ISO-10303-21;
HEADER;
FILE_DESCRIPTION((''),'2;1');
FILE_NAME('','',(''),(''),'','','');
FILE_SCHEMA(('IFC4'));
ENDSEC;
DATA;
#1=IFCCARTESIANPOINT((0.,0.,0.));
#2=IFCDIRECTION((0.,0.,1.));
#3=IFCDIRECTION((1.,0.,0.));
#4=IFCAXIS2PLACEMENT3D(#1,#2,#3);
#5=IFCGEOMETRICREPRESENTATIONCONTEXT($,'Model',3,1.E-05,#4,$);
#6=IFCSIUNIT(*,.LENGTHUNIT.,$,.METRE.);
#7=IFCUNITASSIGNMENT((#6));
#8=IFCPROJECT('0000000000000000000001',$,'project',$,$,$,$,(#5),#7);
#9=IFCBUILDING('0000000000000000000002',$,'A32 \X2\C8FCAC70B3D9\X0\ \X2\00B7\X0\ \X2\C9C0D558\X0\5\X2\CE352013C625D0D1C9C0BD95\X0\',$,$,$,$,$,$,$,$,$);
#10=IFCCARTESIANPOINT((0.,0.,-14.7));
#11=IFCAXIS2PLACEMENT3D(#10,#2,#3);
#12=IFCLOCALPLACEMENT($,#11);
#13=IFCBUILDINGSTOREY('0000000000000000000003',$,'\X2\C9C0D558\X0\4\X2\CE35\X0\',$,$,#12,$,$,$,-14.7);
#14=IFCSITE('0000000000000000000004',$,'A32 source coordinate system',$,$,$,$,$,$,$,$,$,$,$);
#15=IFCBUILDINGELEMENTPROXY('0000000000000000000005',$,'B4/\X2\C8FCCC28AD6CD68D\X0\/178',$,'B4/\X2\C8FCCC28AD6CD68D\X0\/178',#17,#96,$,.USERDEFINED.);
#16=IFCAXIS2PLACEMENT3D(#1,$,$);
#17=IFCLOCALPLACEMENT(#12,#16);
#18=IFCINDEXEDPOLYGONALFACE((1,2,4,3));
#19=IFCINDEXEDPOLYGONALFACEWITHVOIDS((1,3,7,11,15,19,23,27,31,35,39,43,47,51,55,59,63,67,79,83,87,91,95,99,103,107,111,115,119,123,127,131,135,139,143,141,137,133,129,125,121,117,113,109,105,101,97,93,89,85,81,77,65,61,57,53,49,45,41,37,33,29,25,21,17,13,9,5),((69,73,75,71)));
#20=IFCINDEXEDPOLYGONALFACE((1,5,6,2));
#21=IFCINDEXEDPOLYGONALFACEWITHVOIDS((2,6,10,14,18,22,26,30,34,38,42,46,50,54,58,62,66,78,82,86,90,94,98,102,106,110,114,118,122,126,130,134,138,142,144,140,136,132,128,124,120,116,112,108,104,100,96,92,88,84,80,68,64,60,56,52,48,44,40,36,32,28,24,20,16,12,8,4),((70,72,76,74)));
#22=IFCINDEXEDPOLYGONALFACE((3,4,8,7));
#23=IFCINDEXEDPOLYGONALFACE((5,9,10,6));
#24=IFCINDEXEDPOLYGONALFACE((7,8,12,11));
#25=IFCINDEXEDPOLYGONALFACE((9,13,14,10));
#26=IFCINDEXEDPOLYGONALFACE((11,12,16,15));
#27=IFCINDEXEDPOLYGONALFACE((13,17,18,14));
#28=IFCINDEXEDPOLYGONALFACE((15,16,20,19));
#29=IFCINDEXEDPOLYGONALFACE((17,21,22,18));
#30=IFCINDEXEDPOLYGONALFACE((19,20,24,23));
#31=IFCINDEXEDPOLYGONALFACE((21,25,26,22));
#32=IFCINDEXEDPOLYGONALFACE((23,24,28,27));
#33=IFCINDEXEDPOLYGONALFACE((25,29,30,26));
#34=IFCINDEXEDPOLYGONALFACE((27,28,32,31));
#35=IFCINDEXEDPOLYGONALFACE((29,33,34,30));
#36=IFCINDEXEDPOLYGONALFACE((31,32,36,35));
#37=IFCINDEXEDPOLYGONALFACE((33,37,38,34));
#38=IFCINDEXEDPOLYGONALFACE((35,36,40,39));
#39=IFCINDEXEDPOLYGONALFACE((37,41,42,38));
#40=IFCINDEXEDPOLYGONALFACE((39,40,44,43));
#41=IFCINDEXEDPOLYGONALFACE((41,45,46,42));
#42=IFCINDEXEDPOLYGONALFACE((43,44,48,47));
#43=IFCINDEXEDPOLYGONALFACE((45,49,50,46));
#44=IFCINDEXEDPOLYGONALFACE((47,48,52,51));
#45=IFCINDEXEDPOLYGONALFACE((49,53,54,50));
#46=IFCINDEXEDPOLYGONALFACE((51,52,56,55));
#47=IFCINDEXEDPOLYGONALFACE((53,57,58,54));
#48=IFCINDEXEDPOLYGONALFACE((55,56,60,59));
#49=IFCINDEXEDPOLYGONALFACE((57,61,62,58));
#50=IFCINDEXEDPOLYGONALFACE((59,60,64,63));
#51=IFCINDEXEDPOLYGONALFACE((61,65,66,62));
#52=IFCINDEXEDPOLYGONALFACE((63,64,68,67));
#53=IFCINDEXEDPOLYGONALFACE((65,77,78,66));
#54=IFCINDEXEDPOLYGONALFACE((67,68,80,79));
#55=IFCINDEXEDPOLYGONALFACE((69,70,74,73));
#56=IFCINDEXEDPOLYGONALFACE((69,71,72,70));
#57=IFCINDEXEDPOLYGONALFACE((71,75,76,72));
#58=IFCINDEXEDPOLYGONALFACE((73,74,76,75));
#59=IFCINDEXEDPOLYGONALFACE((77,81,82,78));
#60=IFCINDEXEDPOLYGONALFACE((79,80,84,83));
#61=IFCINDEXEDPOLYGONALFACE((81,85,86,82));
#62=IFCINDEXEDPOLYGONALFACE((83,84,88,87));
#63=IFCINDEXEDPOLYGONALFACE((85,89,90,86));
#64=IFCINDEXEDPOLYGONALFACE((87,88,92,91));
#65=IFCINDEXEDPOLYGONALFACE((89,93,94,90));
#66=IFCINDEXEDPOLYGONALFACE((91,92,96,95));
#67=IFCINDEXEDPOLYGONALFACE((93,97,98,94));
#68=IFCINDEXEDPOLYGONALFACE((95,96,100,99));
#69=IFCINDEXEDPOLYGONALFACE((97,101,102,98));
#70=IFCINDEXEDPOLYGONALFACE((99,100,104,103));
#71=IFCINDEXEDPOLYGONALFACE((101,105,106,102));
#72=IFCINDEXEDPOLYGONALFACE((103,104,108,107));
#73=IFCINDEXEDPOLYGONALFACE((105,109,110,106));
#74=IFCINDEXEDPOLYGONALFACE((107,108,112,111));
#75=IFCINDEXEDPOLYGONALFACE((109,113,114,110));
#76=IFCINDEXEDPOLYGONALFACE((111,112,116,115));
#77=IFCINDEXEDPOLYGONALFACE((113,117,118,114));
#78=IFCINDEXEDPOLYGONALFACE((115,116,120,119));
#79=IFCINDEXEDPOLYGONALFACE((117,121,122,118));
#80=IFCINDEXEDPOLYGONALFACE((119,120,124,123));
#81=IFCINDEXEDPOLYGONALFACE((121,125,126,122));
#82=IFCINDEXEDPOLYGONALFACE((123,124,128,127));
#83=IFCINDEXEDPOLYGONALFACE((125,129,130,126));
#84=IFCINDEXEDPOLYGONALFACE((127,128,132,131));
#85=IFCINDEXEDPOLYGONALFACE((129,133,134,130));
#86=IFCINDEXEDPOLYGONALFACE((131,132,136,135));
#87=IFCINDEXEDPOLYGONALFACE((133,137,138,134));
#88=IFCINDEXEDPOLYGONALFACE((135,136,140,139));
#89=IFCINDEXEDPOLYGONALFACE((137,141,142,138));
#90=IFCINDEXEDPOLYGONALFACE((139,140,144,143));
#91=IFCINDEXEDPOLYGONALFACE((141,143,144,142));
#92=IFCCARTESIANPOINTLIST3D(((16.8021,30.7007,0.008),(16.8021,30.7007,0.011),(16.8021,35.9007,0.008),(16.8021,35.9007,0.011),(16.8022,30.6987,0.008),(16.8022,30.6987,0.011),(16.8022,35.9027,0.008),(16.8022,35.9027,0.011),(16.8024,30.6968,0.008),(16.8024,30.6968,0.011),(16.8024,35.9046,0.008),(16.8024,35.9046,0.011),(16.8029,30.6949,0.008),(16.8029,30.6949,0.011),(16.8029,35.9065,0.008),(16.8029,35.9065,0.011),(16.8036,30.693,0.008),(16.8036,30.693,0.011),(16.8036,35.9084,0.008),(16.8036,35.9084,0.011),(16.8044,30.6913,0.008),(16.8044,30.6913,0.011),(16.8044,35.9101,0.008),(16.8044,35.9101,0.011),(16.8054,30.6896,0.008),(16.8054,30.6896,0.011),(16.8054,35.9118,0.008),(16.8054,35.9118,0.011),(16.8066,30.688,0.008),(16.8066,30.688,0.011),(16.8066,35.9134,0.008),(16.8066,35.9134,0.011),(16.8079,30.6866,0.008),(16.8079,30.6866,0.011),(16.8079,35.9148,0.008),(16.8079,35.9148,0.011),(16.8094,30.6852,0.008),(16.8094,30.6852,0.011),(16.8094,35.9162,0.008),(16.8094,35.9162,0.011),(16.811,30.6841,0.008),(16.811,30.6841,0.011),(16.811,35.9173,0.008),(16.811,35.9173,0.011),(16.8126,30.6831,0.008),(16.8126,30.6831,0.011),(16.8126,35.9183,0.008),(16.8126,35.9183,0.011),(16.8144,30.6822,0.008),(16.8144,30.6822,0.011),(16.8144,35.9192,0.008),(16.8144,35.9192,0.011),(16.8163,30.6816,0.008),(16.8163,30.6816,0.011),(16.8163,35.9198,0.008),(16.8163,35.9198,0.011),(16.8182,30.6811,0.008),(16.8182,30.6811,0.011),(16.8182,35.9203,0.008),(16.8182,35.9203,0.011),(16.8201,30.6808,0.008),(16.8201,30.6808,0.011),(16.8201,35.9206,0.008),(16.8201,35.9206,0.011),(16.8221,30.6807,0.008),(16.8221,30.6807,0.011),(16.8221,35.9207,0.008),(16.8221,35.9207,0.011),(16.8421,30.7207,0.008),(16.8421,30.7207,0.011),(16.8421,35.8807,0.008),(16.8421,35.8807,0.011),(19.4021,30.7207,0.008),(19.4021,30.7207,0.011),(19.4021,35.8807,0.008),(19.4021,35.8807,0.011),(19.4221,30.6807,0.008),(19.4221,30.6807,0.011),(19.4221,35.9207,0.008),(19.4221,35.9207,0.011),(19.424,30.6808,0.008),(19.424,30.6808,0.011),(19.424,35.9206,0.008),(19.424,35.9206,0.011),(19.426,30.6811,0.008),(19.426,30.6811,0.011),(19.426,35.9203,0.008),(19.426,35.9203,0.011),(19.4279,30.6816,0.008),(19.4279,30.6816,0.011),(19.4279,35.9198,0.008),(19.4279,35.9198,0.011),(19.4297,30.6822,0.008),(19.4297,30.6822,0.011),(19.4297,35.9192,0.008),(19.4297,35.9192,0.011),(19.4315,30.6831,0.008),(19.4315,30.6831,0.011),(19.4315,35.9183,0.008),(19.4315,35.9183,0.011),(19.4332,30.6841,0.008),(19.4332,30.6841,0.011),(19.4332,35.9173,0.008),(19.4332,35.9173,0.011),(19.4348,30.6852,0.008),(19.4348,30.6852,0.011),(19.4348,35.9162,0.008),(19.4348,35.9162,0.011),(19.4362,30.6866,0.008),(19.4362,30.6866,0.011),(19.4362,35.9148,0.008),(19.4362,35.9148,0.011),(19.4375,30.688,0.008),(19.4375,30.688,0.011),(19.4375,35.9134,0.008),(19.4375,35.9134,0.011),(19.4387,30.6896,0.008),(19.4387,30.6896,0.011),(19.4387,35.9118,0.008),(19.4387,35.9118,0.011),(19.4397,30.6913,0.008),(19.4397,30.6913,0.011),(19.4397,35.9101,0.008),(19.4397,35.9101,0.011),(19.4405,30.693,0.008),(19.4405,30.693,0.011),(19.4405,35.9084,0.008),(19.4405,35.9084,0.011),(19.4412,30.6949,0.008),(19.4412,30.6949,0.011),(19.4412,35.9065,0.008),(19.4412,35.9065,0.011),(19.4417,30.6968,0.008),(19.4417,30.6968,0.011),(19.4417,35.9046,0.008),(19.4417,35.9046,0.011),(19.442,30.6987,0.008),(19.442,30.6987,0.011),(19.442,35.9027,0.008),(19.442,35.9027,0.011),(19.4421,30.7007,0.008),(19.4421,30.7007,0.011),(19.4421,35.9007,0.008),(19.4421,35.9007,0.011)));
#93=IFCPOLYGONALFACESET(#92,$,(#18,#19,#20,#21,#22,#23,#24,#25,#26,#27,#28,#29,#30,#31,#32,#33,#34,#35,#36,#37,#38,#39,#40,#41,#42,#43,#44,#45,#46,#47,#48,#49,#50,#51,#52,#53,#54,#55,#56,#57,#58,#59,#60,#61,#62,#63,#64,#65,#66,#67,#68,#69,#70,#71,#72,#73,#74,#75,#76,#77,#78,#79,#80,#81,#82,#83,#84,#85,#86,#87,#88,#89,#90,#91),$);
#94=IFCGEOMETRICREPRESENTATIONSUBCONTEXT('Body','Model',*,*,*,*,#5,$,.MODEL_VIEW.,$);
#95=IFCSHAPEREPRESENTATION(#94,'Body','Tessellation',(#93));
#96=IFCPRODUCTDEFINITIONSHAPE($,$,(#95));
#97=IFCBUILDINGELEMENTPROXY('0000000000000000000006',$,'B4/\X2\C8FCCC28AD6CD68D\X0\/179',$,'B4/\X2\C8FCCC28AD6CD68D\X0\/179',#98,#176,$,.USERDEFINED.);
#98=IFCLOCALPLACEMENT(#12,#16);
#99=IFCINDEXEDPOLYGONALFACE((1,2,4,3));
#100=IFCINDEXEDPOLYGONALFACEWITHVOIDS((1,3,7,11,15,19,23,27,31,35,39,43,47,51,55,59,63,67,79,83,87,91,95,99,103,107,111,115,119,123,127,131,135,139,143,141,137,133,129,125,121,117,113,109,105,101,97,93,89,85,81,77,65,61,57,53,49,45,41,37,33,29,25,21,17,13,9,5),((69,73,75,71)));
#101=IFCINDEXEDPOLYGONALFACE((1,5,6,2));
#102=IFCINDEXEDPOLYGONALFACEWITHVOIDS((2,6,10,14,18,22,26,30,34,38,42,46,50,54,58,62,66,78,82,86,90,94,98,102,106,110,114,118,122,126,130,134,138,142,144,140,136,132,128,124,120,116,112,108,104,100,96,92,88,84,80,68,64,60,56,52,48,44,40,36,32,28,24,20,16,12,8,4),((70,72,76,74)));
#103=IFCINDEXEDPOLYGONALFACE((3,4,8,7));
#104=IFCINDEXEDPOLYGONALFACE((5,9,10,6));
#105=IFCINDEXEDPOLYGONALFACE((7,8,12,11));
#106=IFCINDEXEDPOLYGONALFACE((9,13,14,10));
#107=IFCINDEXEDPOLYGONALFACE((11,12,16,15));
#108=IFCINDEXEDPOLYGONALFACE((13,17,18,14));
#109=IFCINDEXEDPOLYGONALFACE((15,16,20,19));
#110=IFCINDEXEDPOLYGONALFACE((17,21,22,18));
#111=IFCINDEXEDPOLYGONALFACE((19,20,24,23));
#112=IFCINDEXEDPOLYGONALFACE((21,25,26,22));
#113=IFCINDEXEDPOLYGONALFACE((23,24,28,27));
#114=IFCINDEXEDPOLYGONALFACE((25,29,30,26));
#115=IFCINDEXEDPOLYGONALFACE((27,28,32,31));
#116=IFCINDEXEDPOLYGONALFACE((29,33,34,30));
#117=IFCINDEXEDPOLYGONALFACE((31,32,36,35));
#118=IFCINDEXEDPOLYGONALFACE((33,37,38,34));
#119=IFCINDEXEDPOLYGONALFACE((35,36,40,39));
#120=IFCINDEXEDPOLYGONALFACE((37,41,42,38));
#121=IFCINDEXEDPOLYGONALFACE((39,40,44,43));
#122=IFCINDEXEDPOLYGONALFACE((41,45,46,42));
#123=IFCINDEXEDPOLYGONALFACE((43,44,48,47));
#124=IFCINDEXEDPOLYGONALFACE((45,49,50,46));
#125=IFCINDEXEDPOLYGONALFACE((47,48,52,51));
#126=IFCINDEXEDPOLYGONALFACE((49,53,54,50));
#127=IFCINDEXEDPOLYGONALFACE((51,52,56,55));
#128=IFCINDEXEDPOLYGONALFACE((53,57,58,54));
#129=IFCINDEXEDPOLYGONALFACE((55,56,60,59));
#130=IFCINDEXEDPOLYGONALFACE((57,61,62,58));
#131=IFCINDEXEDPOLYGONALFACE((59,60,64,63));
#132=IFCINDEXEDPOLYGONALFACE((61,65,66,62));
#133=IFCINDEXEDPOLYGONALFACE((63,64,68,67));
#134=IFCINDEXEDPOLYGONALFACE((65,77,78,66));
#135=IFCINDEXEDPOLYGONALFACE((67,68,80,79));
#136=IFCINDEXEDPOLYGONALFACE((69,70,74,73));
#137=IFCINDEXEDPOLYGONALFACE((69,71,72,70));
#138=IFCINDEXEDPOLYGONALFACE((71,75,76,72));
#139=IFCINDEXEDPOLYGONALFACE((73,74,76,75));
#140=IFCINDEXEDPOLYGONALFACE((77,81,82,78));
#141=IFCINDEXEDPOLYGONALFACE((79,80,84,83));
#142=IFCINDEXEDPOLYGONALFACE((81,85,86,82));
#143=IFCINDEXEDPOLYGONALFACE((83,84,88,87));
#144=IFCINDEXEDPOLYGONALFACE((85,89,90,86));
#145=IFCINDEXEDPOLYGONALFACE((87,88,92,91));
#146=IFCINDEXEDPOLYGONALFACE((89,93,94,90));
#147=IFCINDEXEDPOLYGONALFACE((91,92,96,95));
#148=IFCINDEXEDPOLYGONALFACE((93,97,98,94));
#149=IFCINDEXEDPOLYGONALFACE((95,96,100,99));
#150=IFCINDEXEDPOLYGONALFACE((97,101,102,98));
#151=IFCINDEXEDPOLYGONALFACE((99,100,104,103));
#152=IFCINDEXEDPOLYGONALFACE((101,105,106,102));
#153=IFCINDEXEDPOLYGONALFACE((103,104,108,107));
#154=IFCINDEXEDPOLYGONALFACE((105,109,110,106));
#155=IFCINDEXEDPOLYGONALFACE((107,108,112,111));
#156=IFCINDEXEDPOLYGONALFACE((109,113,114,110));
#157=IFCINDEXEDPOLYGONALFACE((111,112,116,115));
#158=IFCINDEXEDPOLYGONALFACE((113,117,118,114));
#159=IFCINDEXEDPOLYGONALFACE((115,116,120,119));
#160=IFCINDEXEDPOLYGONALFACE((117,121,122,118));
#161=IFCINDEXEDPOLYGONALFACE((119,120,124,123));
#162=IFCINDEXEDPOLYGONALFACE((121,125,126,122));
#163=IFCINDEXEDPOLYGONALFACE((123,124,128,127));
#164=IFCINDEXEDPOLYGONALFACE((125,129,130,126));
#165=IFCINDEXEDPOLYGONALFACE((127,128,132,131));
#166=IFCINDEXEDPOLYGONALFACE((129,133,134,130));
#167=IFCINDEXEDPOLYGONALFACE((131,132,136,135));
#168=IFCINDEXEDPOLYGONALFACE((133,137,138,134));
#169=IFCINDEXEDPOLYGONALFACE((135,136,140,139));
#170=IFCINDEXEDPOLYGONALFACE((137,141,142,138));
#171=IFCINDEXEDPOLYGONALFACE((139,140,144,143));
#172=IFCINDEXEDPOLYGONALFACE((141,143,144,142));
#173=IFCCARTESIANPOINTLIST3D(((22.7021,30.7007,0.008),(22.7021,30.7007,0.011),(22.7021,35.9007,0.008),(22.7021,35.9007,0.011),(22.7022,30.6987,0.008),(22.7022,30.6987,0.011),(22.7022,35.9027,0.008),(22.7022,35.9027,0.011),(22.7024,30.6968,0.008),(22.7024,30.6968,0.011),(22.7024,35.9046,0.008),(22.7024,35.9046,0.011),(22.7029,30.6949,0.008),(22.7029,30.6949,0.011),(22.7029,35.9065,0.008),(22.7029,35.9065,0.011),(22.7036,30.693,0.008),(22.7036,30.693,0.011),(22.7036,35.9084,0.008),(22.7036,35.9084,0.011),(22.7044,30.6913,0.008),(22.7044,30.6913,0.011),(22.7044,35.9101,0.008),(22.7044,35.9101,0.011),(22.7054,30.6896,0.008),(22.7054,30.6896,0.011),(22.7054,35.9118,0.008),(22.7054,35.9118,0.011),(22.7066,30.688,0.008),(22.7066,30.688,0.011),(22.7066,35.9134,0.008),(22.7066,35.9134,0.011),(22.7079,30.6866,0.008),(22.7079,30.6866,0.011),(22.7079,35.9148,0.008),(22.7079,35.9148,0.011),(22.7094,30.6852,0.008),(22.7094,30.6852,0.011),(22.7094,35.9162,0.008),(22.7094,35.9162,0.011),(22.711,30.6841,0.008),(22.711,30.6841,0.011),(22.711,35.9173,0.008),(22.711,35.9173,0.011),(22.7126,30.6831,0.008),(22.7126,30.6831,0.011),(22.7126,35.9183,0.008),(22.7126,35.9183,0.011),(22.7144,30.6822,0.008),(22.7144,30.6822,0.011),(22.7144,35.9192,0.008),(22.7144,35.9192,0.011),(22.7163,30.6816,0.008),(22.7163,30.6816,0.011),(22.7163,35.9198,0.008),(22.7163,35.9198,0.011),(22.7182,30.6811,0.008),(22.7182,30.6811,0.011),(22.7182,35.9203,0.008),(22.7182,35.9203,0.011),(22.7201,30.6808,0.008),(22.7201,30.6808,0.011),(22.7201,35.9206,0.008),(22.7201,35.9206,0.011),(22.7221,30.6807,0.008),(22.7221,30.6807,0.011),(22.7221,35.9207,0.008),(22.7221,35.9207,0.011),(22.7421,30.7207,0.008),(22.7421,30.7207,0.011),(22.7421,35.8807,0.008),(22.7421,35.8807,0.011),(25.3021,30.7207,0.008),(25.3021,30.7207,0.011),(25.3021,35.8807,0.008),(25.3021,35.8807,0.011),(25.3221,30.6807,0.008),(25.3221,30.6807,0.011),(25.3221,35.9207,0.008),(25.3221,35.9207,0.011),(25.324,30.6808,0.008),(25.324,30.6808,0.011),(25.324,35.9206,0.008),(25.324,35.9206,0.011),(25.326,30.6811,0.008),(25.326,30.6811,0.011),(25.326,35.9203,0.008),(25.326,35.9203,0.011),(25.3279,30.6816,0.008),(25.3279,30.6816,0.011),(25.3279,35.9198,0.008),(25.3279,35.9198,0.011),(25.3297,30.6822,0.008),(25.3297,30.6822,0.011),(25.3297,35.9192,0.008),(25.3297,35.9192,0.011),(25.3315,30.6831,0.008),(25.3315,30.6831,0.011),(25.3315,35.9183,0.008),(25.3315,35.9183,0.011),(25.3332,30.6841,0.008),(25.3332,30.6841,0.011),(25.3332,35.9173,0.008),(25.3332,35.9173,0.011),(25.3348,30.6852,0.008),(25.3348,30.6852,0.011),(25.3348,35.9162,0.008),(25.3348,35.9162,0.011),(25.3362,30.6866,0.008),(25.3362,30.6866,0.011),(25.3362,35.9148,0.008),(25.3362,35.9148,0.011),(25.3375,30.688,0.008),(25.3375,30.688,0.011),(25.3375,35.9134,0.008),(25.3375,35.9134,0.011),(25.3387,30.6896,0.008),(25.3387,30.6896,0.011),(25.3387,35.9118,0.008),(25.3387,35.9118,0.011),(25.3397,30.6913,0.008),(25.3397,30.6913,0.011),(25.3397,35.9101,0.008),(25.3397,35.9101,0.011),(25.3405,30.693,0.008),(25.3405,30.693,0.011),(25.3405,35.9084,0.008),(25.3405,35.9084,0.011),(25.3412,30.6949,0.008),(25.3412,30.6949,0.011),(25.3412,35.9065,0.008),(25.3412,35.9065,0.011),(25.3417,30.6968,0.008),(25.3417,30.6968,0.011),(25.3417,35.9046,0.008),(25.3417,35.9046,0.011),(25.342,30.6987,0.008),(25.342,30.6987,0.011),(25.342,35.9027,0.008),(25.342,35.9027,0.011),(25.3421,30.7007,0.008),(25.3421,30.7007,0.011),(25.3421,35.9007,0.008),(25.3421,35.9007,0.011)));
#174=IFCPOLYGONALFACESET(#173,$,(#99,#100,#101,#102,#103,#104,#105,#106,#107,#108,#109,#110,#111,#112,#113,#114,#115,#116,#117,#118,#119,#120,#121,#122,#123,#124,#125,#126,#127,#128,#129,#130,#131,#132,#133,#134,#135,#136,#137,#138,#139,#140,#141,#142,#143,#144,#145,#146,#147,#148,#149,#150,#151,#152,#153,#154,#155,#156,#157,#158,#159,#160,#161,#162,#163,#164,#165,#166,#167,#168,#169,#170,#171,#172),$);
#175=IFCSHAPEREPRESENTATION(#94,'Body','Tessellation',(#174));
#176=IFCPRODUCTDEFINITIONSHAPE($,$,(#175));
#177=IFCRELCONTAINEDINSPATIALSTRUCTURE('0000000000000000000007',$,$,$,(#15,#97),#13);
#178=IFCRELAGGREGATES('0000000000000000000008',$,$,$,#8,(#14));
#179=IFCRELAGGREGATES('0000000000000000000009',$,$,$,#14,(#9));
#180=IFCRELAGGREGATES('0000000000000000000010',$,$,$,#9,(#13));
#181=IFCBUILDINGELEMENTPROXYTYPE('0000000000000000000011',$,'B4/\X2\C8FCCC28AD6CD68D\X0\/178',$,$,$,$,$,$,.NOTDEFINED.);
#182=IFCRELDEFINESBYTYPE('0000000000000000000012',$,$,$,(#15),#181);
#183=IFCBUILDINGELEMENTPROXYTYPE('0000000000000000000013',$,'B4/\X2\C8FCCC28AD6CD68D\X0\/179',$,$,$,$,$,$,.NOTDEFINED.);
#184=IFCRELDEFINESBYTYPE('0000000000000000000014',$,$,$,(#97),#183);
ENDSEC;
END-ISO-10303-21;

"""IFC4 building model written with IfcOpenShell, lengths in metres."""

from ifc_helpers import new_model, si_unit, frame, origin, origin_with_axes, place, context, subcontext, project, spatial, polyline, outline, extrude, source, transform, mapped, type_object, type_shapes, element, save


model = new_model("IFC4")

# Units and contexts
model_context = context("Model", 3, precision=1e-05, world=origin_with_axes())
body_context = subcontext(model_context, "Body", "Model", "MODEL_VIEW")
ifc_project = project(units=[si_unit("LENGTHUNIT", "METRE")], contexts=[model_context])

# Site, building, storey
site = spatial("IfcSite", under=ifc_project, Name="A32 source coordinate system")
building = spatial("IfcBuilding", under=site, Name="A32 주거동 · 지하5층–옥탑지붕")
storey_placement = place(None, frame((0.0, 0.0, -14.7), z_axis=(0.0, 0.0, 1.0), x_axis=(1.0, 0.0, 0.0)))
storey = spatial("IfcBuildingStorey", under=building, at=storey_placement, Name="지하4층", Elevation=-14.7)

# Building element proxies
building_element_proxy_type_1 = type_object("IfcBuildingElementProxyType", Name="B4/주차구획/178", PredefinedType="NOTDEFINED")
shared_shape_1 = source(origin(), body_context, "Body", "SweptSolid", [
    extrude(outline(polyline([(16.8021, 35.9007), (16.8022, 35.9027), (16.8024, 35.9046), (16.8029, 35.9065), (16.8036, 35.9084), (16.8044, 35.9101), (16.8054, 35.9118), (16.8066, 35.9134), (16.8079, 35.9148), (16.8094, 35.9162), (16.811, 35.9173), (16.8126, 35.9183), (16.8144, 35.9192), (16.8163, 35.9198), (16.8182, 35.9203), (16.8201, 35.9206), (16.8221, 35.9207), (19.4221, 35.9207), (19.424, 35.9206), (19.426, 35.9203), (19.4279, 35.9198), (19.4297, 35.9192), (19.4315, 35.9183), (19.4332, 35.9173), (19.4348, 35.9162), (19.4362, 35.9148), (19.4375, 35.9134), (19.4387, 35.9118), (19.4397, 35.9101), (19.4405, 35.9084), (19.4412, 35.9065), (19.4417, 35.9046), (19.442, 35.9027), (19.4421, 35.9007), (19.4421, 30.7007), (19.442, 30.6987), (19.4417, 30.6968), (19.4412, 30.6949), (19.4405, 30.693), (19.4397, 30.6913), (19.4387, 30.6896), (19.4375, 30.688), (19.4362, 30.6866), (19.4348, 30.6852), (19.4332, 30.6841), (19.4315, 30.6831), (19.4297, 30.6822), (19.4279, 30.6816), (19.426, 30.6811), (19.424, 30.6808), (19.4221, 30.6807), (16.8221, 30.6807), (16.8201, 30.6808), (16.8182, 30.6811), (16.8163, 30.6816), (16.8144, 30.6822), (16.8126, 30.6831), (16.811, 30.6841), (16.8094, 30.6852), (16.8079, 30.6866), (16.8066, 30.688), (16.8054, 30.6896), (16.8044, 30.6913), (16.8036, 30.693), (16.8029, 30.6949), (16.8024, 30.6968), (16.8022, 30.6987), (16.8021, 30.7007), (16.8021, 35.9007)]), holes=[polyline([(16.8421, 35.8807), (16.8421, 30.7207), (19.4021, 30.7207), (19.4021, 35.8807), (16.8421, 35.8807)])]), frame((0.0, 0.0, 0.008)), (0.0, 0.0, 1.0), 0.003),
])
type_shapes(building_element_proxy_type_1, [shared_shape_1])
proxy_1_placement = place(storey_placement, origin_with_axes())
element("IfcBuildingElementProxy", 1, at=proxy_1_placement, inside=storey, type_object=building_element_proxy_type_1, Name="B4/주차구획/178", ObjectType="B4/주차구획/178", PredefinedType="USERDEFINED", context=body_context, shape_type="MappedRepresentation", body=[
    mapped(shared_shape_1, transform((0.0, 0.0, 0.0), scale=1.0)),
])
building_element_proxy_type_2 = type_object("IfcBuildingElementProxyType", Name="B4/주차구획/179", PredefinedType="NOTDEFINED")
shared_shape_2 = source(origin(), body_context, "Body", "SweptSolid", [
    extrude(outline(polyline([(22.7021, 35.9007), (22.7022, 35.9027), (22.7024, 35.9046), (22.7029, 35.9065), (22.7036, 35.9084), (22.7044, 35.9101), (22.7054, 35.9118), (22.7066, 35.9134), (22.7079, 35.9148), (22.7094, 35.9162), (22.711, 35.9173), (22.7126, 35.9183), (22.7144, 35.9192), (22.7163, 35.9198), (22.7182, 35.9203), (22.7201, 35.9206), (22.7221, 35.9207), (25.3221, 35.9207), (25.324, 35.9206), (25.326, 35.9203), (25.3279, 35.9198), (25.3297, 35.9192), (25.3315, 35.9183), (25.3332, 35.9173), (25.3348, 35.9162), (25.3362, 35.9148), (25.3375, 35.9134), (25.3387, 35.9118), (25.3397, 35.9101), (25.3405, 35.9084), (25.3412, 35.9065), (25.3417, 35.9046), (25.342, 35.9027), (25.3421, 35.9007), (25.3421, 30.7007), (25.342, 30.6987), (25.3417, 30.6968), (25.3412, 30.6949), (25.3405, 30.693), (25.3397, 30.6913), (25.3387, 30.6896), (25.3375, 30.688), (25.3362, 30.6866), (25.3348, 30.6852), (25.3332, 30.6841), (25.3315, 30.6831), (25.3297, 30.6822), (25.3279, 30.6816), (25.326, 30.6811), (25.324, 30.6808), (25.3221, 30.6807), (22.7221, 30.6807), (22.7201, 30.6808), (22.7182, 30.6811), (22.7163, 30.6816), (22.7144, 30.6822), (22.7126, 30.6831), (22.711, 30.6841), (22.7094, 30.6852), (22.7079, 30.6866), (22.7066, 30.688), (22.7054, 30.6896), (22.7044, 30.6913), (22.7036, 30.693), (22.7029, 30.6949), (22.7024, 30.6968), (22.7022, 30.6987), (22.7021, 30.7007), (22.7021, 35.9007)]), holes=[polyline([(22.7421, 35.8807), (22.7421, 30.7207), (25.3021, 30.7207), (25.3021, 35.8807), (22.7421, 35.8807)])]), frame((0.0, 0.0, 0.008)), (0.0, 0.0, 1.0), 0.003),
])
type_shapes(building_element_proxy_type_2, [shared_shape_2])
proxy_2_placement = place(storey_placement, origin_with_axes())
element("IfcBuildingElementProxy", 2, at=proxy_2_placement, inside=storey, type_object=building_element_proxy_type_2, Name="B4/주차구획/179", ObjectType="B4/주차구획/179", PredefinedType="USERDEFINED", context=body_context, shape_type="MappedRepresentation", body=[
    mapped(shared_shape_2, transform((0.0, 0.0, 0.0), scale=1.0)),
])

save(model, "model.ifc")
